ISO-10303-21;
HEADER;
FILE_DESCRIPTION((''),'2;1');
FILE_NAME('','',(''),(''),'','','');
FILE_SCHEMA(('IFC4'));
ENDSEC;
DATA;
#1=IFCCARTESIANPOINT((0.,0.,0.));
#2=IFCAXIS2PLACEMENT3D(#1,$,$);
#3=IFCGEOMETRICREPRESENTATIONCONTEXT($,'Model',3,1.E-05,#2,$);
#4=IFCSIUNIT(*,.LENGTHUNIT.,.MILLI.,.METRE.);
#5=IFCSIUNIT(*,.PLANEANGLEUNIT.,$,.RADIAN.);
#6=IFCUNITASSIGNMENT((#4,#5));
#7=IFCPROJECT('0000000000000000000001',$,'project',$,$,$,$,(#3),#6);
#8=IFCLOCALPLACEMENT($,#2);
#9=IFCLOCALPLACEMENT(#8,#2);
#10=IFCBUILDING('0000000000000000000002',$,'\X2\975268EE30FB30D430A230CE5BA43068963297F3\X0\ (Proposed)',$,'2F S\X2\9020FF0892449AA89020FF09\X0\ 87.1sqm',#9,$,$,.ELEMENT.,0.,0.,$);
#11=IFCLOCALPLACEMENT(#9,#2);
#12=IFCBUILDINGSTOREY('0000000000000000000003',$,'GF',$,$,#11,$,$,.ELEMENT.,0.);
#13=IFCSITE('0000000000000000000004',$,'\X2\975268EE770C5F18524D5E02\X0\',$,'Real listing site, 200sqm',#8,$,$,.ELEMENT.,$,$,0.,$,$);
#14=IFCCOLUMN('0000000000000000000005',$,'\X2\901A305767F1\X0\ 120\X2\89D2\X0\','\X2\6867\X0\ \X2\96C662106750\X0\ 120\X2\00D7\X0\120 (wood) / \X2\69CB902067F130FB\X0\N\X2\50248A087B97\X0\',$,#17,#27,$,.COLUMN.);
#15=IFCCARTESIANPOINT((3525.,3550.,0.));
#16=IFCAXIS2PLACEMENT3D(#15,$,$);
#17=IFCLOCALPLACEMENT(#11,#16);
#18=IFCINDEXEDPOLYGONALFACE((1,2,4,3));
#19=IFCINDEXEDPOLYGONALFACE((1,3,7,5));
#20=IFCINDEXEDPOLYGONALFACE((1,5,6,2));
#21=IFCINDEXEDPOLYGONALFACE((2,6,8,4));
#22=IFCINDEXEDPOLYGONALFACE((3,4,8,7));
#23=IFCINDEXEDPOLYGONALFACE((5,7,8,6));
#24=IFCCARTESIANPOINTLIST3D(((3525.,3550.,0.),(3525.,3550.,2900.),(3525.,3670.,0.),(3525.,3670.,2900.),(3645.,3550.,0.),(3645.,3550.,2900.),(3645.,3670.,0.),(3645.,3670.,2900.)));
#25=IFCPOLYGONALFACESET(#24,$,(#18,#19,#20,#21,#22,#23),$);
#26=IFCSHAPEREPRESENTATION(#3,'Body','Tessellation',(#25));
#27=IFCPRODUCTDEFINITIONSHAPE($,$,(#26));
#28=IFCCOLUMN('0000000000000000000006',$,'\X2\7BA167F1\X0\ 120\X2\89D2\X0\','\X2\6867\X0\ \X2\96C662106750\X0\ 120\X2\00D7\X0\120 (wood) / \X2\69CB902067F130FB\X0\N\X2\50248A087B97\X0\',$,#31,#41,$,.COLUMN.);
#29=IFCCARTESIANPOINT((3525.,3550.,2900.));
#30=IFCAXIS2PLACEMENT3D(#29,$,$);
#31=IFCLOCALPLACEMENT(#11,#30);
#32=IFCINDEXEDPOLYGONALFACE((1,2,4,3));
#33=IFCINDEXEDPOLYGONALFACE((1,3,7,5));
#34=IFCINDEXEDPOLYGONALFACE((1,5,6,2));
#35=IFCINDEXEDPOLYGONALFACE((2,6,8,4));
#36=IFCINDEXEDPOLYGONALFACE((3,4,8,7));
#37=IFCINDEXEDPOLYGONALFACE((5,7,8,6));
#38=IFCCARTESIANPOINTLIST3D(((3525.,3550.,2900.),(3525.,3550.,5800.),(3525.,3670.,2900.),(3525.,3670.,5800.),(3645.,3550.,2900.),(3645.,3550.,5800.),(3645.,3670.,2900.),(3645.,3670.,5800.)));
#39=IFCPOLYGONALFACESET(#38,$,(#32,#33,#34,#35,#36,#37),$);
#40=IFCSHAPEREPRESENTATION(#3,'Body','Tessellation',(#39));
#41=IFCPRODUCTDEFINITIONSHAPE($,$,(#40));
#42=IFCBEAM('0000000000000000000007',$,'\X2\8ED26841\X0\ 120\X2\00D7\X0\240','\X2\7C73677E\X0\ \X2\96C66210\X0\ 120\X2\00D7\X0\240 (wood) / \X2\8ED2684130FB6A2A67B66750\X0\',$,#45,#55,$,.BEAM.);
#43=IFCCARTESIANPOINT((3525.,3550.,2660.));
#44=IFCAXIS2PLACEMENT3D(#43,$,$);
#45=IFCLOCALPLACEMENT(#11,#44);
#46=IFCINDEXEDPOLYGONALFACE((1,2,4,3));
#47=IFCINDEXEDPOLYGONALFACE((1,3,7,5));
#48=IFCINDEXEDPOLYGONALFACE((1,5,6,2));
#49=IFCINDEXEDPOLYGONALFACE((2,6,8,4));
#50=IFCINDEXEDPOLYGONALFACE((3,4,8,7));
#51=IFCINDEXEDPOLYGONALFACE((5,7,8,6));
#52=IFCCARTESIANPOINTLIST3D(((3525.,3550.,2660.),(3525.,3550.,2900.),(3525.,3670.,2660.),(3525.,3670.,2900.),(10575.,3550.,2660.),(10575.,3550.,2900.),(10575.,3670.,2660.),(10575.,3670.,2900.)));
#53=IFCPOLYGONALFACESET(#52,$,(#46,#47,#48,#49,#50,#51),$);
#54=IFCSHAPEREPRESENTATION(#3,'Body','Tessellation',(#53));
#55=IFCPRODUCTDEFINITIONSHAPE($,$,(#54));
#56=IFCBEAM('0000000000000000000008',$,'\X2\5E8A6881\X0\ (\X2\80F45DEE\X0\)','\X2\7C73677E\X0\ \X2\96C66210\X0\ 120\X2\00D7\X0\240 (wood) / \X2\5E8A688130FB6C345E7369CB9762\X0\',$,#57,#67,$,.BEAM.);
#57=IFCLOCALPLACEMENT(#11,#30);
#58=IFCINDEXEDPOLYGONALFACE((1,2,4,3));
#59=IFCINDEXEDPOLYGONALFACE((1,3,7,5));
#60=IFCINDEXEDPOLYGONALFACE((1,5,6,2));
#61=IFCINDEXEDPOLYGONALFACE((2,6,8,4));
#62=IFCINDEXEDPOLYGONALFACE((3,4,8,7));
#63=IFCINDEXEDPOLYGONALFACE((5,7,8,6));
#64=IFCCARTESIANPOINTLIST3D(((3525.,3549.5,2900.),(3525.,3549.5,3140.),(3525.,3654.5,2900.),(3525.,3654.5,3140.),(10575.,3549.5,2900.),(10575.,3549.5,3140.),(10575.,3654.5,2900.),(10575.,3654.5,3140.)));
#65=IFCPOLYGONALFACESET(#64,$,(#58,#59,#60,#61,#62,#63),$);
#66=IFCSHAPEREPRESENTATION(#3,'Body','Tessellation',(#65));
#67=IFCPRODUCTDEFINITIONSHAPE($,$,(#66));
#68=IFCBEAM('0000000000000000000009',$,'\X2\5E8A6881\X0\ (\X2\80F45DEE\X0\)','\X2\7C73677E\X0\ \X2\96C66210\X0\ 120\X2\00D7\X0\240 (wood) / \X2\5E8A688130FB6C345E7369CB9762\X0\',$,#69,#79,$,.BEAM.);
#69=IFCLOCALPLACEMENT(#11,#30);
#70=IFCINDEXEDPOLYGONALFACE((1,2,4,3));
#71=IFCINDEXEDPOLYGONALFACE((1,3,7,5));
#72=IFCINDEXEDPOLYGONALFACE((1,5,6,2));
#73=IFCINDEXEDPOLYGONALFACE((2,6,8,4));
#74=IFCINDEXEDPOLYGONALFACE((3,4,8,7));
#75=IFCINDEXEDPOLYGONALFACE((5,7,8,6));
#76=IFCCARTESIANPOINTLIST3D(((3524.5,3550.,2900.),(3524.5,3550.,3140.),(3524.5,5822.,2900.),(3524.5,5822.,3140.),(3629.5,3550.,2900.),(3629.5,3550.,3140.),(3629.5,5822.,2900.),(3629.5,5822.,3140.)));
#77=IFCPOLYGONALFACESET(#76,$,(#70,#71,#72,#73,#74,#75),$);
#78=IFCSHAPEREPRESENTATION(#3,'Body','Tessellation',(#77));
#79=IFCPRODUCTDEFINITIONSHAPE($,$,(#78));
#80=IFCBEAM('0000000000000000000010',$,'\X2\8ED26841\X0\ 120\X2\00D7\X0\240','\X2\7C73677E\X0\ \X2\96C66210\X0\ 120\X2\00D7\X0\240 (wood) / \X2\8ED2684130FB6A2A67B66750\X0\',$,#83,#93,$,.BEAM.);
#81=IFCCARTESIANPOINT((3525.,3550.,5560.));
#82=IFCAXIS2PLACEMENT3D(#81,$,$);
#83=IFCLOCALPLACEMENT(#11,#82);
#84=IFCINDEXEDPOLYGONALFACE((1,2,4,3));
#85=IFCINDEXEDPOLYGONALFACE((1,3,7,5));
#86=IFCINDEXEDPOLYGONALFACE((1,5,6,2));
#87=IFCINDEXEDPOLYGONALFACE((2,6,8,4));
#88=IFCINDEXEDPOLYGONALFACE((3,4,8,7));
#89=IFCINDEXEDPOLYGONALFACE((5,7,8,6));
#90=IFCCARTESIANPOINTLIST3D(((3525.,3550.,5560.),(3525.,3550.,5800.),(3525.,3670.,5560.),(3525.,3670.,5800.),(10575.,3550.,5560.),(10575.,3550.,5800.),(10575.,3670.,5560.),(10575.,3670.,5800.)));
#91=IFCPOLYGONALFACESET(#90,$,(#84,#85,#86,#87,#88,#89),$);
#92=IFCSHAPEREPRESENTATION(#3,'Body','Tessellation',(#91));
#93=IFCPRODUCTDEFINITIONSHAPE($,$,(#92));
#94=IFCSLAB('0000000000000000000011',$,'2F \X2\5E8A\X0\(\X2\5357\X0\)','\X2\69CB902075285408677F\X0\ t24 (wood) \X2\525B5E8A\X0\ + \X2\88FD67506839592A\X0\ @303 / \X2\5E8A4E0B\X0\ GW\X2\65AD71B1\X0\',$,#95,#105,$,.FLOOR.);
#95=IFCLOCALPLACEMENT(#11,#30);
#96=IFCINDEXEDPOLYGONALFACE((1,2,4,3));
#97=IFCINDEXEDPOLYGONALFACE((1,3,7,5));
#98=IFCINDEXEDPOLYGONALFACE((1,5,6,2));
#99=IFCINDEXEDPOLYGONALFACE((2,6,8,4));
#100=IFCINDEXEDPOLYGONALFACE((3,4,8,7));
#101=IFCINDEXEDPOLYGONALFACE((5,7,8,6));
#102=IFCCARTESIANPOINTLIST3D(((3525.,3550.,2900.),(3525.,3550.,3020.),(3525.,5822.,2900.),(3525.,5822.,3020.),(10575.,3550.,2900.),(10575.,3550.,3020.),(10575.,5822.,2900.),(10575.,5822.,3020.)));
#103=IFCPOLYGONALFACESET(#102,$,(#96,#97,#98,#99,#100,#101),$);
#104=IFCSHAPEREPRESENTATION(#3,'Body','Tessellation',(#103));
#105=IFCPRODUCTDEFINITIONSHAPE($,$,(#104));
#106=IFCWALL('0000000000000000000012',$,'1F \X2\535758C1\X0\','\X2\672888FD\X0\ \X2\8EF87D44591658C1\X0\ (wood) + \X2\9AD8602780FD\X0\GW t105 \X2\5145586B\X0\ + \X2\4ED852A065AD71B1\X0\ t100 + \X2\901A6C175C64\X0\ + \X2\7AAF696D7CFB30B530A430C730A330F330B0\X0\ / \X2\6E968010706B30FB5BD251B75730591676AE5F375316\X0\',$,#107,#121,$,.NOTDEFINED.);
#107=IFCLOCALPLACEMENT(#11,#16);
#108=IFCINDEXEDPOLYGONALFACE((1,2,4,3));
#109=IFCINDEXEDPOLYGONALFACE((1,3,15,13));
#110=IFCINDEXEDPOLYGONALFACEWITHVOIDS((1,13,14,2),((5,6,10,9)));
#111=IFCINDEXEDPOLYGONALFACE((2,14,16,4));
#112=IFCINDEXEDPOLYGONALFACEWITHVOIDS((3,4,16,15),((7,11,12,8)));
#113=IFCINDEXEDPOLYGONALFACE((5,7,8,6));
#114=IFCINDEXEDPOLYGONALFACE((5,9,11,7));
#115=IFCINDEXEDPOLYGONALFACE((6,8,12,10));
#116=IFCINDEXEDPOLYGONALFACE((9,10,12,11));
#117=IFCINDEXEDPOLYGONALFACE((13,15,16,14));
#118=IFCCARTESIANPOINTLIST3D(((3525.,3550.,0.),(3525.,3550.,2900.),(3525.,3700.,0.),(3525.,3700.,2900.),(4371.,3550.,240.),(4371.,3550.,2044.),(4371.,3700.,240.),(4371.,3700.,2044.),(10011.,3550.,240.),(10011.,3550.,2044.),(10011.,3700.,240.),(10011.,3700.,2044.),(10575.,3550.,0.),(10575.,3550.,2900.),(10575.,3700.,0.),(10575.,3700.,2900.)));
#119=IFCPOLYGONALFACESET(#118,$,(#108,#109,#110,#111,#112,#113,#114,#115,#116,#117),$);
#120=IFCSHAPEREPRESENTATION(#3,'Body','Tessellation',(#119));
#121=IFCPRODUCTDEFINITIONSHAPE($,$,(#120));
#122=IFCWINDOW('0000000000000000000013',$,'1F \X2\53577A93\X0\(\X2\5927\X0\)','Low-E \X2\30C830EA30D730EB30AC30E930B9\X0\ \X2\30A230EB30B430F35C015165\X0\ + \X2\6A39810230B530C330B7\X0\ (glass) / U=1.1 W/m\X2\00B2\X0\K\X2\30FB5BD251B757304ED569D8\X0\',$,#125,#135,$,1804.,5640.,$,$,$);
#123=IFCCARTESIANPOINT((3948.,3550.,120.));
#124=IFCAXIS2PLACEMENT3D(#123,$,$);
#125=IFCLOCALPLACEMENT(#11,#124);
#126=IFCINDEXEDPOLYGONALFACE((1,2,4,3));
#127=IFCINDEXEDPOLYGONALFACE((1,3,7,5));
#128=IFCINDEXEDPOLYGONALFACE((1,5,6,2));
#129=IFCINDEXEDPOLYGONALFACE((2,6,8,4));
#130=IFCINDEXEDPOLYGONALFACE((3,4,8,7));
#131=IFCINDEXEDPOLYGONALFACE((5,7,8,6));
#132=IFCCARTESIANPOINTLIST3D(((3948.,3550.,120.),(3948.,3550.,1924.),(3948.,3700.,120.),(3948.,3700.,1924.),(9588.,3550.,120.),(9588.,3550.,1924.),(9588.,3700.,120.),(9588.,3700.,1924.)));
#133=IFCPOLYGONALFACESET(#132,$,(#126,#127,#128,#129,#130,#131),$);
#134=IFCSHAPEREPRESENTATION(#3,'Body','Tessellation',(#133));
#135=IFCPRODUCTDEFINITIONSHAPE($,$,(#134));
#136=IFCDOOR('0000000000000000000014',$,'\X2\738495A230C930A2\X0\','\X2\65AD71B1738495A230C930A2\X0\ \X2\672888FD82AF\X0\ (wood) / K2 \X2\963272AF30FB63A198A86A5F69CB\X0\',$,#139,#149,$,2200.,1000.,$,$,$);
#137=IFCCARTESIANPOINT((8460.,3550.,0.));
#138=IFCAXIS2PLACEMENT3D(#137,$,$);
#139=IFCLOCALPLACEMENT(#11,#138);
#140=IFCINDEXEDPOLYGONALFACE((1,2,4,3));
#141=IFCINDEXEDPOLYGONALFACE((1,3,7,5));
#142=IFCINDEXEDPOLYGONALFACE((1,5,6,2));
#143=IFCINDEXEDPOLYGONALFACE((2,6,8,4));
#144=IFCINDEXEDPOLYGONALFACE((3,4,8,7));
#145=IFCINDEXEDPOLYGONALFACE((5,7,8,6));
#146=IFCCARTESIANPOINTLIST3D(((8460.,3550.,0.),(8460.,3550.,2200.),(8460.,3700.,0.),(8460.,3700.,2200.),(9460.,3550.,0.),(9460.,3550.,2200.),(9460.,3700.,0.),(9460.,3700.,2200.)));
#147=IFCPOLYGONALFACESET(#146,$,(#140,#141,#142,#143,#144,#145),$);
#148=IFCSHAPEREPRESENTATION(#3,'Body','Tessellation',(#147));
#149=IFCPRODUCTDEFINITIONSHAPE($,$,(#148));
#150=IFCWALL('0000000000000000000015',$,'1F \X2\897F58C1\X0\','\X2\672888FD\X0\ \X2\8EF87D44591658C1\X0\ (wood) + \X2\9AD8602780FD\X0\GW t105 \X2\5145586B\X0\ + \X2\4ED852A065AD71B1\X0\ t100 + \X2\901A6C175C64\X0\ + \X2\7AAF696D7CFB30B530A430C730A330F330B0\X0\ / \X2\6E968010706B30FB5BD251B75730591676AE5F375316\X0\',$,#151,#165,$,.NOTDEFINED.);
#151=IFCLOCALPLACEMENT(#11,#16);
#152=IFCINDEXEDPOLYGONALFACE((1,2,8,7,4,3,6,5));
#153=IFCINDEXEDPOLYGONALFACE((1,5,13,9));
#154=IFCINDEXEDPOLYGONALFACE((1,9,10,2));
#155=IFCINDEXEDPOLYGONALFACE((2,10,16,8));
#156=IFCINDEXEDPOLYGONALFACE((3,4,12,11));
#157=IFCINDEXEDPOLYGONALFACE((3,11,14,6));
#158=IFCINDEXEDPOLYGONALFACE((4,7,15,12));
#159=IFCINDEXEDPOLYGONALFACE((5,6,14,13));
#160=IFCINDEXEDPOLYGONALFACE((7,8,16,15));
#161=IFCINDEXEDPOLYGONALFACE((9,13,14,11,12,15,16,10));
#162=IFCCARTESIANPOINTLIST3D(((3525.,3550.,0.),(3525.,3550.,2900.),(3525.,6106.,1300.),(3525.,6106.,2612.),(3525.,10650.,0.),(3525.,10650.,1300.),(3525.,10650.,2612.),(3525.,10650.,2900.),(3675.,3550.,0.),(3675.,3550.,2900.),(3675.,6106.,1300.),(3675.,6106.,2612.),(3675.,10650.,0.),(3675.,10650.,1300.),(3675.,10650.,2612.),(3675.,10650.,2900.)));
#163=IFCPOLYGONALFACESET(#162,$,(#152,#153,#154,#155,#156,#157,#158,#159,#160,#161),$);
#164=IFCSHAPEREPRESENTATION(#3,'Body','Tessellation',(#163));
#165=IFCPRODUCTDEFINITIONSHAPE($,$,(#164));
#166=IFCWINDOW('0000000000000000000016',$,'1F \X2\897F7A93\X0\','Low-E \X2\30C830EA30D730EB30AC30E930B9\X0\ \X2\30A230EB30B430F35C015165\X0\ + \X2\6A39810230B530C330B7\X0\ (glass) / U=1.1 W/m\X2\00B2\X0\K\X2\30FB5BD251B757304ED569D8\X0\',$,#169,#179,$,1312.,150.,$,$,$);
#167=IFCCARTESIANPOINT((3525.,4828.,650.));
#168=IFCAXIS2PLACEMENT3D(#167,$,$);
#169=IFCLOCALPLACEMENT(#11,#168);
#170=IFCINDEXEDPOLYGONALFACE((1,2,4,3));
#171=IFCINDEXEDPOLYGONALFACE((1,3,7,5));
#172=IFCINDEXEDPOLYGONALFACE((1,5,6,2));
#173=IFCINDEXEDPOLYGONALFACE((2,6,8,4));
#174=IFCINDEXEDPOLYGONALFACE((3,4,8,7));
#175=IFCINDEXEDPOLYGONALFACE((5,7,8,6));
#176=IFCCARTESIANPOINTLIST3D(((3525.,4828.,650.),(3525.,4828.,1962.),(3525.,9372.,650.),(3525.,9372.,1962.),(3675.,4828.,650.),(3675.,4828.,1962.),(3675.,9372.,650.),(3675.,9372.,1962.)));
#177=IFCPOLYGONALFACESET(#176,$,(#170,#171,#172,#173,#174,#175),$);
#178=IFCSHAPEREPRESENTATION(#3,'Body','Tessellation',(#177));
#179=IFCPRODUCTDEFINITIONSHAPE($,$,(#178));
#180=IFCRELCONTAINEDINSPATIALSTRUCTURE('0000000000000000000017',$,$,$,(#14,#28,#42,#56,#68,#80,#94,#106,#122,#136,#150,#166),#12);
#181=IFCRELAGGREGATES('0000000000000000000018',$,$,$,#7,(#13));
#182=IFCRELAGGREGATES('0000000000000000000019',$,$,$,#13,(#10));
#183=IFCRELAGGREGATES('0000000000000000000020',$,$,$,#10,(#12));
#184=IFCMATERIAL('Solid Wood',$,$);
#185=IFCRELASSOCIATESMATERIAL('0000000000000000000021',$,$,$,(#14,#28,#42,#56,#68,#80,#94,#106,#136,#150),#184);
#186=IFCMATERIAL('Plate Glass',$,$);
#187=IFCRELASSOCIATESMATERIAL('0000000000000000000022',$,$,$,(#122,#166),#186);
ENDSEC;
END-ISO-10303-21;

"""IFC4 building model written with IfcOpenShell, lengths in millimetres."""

from ifc_helpers import new_model, si_unit, frame, frame_2d, origin, place, context, project, spatial, rectangle, extrude, material, element, fill, save


model = new_model("IFC4")

# Units and contexts
model_context = context("Model", 3, precision=1e-05, world=origin())
ifc_project = project(units=[si_unit("LENGTHUNIT", "METRE", prefix="MILLI"), si_unit("PLANEANGLEUNIT", "RADIAN")], contexts=[model_context])

# Site, building, storey
site_placement = place(None, origin())
site = spatial("IfcSite", under=ifc_project, at=site_placement, Name="青森県弘前市", ObjectType="Real listing site, 200sqm", CompositionType="ELEMENT", RefElevation=0.0)
building_placement = place(site_placement, origin())
building = spatial("IfcBuilding", under=site, at=building_placement, Name="青森・ピアノ室と防音 (Proposed)", ObjectType="2F S造（鉄骨造） 87.1sqm", CompositionType="ELEMENT", ElevationOfRefHeight=0.0, ElevationOfTerrain=0.0)
storey_placement = place(building_placement, origin())
storey = spatial("IfcBuildingStorey", under=building, at=storey_placement, Name="GF", CompositionType="ELEMENT", Elevation=0.0)

# Columns
ifc_material_1 = material(Name="Solid Wood")
column_1_placement = place(storey_placement, frame((3525.0, 3550.0, 0.0)))
element("IfcColumn", 1, at=column_1_placement, inside=storey, material=ifc_material_1, Name="通し柱 120角", Description="桧 集成材 120×120 (wood) / 構造柱・N値計算", PredefinedType="COLUMN", context=model_context, shape_type="SweptSolid", body=[
    extrude(rectangle(XDim=120.0, YDim=120.0, at=frame_2d((60.0, 60.0))), frame((3525.0, 3550.0, 0.0)), (0.0, 0.0, 1.0), 2900.0),
])
column_2_placement = place(storey_placement, frame((3525.0, 3550.0, 2900.0)))
element("IfcColumn", 2, at=column_2_placement, inside=storey, material=ifc_material_1, Name="管柱 120角", Description="桧 集成材 120×120 (wood) / 構造柱・N値計算", PredefinedType="COLUMN", context=model_context, shape_type="SweptSolid", body=[
    extrude(rectangle(XDim=120.0, YDim=120.0, at=frame_2d((60.0, 60.0))), frame((3525.0, 3550.0, 2900.0)), (0.0, 0.0, 1.0), 2900.0),
])

# Beams
beam_1_placement = place(storey_placement, frame((3525.0, 3550.0, 2660.0)))
element("IfcBeam", 3, at=beam_1_placement, inside=storey, material=ifc_material_1, Name="軒桁 120×240", Description="米松 集成 120×240 (wood) / 軒桁・横架材", PredefinedType="BEAM", context=model_context, shape_type="SweptSolid", body=[
    extrude(rectangle(XDim=7050.0, YDim=120.0, at=frame_2d((3525.0, 60.0))), frame((3525.0, 3550.0, 2660.0)), (0.0, 0.0, 1.0), 240.0),
])
beam_2_placement = place(storey_placement, frame((3525.0, 3550.0, 2900.0)))
element("IfcBeam", 4, at=beam_2_placement, inside=storey, material=ifc_material_1, Name="床梁 (胴差)", Description="米松 集成 120×240 (wood) / 床梁・水平構面", PredefinedType="BEAM", context=model_context, shape_type="SweptSolid", body=[
    extrude(rectangle(XDim=7050.0, YDim=105.0, at=frame_2d((3525.0, 52.0))), frame((3525.0, 3550.0, 2900.0)), (0.0, 0.0, 1.0), 240.0),
])
beam_3_placement = place(storey_placement, frame((3525.0, 3550.0, 2900.0)))
element("IfcBeam", 5, at=beam_3_placement, inside=storey, material=ifc_material_1, Name="床梁 (胴差)", Description="米松 集成 120×240 (wood) / 床梁・水平構面", PredefinedType="BEAM", context=model_context, shape_type="SweptSolid", body=[
    extrude(rectangle(XDim=105.0, YDim=2272.0, at=frame_2d((52.0, 1136.0))), frame((3525.0, 3550.0, 2900.0)), (0.0, 0.0, 1.0), 240.0),
])
beam_4_placement = place(storey_placement, frame((3525.0, 3550.0, 5560.0)))
element("IfcBeam", 6, at=beam_4_placement, inside=storey, material=ifc_material_1, Name="軒桁 120×240", Description="米松 集成 120×240 (wood) / 軒桁・横架材", PredefinedType="BEAM", context=model_context, shape_type="SweptSolid", body=[
    extrude(rectangle(XDim=7050.0, YDim=120.0, at=frame_2d((3525.0, 60.0))), frame((3525.0, 3550.0, 5560.0)), (0.0, 0.0, 1.0), 240.0),
])

# Slab
slab_1_placement = place(storey_placement, frame((3525.0, 3550.0, 2900.0)))
element("IfcSlab", 7, at=slab_1_placement, inside=storey, material=ifc_material_1, Name="2F 床(南)", Description="構造用合板 t24 (wood) 剛床 + 製材根太 @303 / 床下 GW断熱", PredefinedType="FLOOR", context=model_context, shape_type="SweptSolid", body=[
    extrude(rectangle(XDim=7050.0, YDim=2272.0, at=frame_2d((3525.0, 1136.0))), frame((3525.0, 3550.0, 2900.0)), (0.0, 0.0, 1.0), 120.0),
])

# Wall, openings, window, door
wall_1_placement = place(storey_placement, frame((3525.0, 3550.0, 0.0)))
wall_1 = element("IfcWall", 8, at=wall_1_placement, inside=storey, material=ifc_material_1, Name="1F 南壁", Description="木製 軸組外壁 (wood) + 高性能GW t105 充填 + 付加断熱 t100 + 通気層 + 窯業系サイディング / 準耐火・寒冷地外皮強化", PredefinedType="NOTDEFINED", context=model_context, shape_type="SweptSolid", body=[
    extrude(rectangle(XDim=7050.0, YDim=150.0, at=frame_2d((3525.0, 75.0))), frame((3525.0, 3550.0, 0.0)), (0.0, 0.0, 1.0), 2900.0),
])
opening_1_placement = place(storey_placement, frame((3948.0, 3550.0, 120.0)))
opening_1 = element("IfcOpeningElement", 9, at=opening_1_placement, cuts=wall_1, PredefinedType="NOTDEFINED", context=model_context, shape_type="SweptSolid", body=[
    extrude(rectangle(XDim=5640.0, YDim=150.0, at=frame_2d((2820.0, 75.0))), frame((3948.0, 3550.0, 120.0)), (0.0, 0.0, 1.0), 1804.0),
])
opening_2_placement = place(storey_placement, frame((8460.0, 3550.0, 0.0)))
opening_2 = element("IfcOpeningElement", 10, at=opening_2_placement, cuts=wall_1, PredefinedType="NOTDEFINED", context=model_context, shape_type="SweptSolid", body=[
    extrude(rectangle(XDim=1000.0, YDim=150.0, at=frame_2d((500.0, 75.0))), frame((8460.0, 3550.0, 0.0)), (0.0, 0.0, 1.0), 2200.0),
])
ifc_material_2 = material(Name="Plate Glass")
window_1_placement = place(storey_placement, frame((3948.0, 3550.0, 120.0)))
window_1 = element("IfcWindow", 11, at=window_1_placement, inside=storey, material=ifc_material_2, Name="1F 南窓(大)", Description="Low-E トリプルガラス アルゴン封入 + 樹脂サッシ (glass) / U=1.1 W/m²K・寒冷地仕様", OverallHeight=1804.0, OverallWidth=5640.0, context=model_context, shape_type="SweptSolid", body=[
    extrude(rectangle(XDim=5640.0, YDim=150.0, at=frame_2d((2820.0, 75.0))), frame((3948.0, 3550.0, 120.0)), (0.0, 0.0, 1.0), 1804.0),
])
fill(opening_1, window_1)
door_placement = place(storey_placement, frame((8460.0, 3550.0, 0.0)))
door = element("IfcDoor", 12, at=door_placement, inside=storey, material=ifc_material_1, Name="玄関ドア", Description="断熱玄関ドア 木製芯 (wood) / K2 防犯・採風機構", OverallHeight=2200.0, OverallWidth=1000.0, context=model_context, shape_type="SweptSolid", body=[
    extrude(rectangle(XDim=1000.0, YDim=150.0, at=frame_2d((500.0, 75.0))), frame((8460.0, 3550.0, 0.0)), (0.0, 0.0, 1.0), 2200.0),
])
fill(opening_2, door)

# Wall, opening, window
wall_2_placement = place(storey_placement, frame((3525.0, 3550.0, 0.0)))
wall_2 = element("IfcWall", 13, at=wall_2_placement, inside=storey, material=ifc_material_1, Name="1F 西壁", Description="木製 軸組外壁 (wood) + 高性能GW t105 充填 + 付加断熱 t100 + 通気層 + 窯業系サイディング / 準耐火・寒冷地外皮強化", PredefinedType="NOTDEFINED", context=model_context, shape_type="SweptSolid", body=[
    extrude(rectangle(XDim=150.0, YDim=7100.0, at=frame_2d((75.0, 3550.0))), frame((3525.0, 3550.0, 0.0)), (0.0, 0.0, 1.0), 2900.0),
])
opening_3_placement = place(storey_placement, frame((3525.0, 4828.0, 650.0)))
opening_3 = element("IfcOpeningElement", 14, at=opening_3_placement, cuts=wall_2, PredefinedType="NOTDEFINED", context=model_context, shape_type="SweptSolid", body=[
    extrude(rectangle(XDim=150.0, YDim=4544.0, at=frame_2d((75.0, 2272.0))), frame((3525.0, 4828.0, 650.0)), (0.0, 0.0, 1.0), 1312.0),
])
window_2_placement = place(storey_placement, frame((3525.0, 4828.0, 650.0)))
window_2 = element("IfcWindow", 15, at=window_2_placement, inside=storey, material=ifc_material_2, Name="1F 西窓", Description="Low-E トリプルガラス アルゴン封入 + 樹脂サッシ (glass) / U=1.1 W/m²K・寒冷地仕様", OverallHeight=1312.0, OverallWidth=150.0, context=model_context, shape_type="SweptSolid", body=[
    extrude(rectangle(XDim=150.0, YDim=4544.0, at=frame_2d((75.0, 2272.0))), frame((3525.0, 4828.0, 650.0)), (0.0, 0.0, 1.0), 1312.0),
])
fill(opening_3, window_2)

save(model, "model.ifc")
